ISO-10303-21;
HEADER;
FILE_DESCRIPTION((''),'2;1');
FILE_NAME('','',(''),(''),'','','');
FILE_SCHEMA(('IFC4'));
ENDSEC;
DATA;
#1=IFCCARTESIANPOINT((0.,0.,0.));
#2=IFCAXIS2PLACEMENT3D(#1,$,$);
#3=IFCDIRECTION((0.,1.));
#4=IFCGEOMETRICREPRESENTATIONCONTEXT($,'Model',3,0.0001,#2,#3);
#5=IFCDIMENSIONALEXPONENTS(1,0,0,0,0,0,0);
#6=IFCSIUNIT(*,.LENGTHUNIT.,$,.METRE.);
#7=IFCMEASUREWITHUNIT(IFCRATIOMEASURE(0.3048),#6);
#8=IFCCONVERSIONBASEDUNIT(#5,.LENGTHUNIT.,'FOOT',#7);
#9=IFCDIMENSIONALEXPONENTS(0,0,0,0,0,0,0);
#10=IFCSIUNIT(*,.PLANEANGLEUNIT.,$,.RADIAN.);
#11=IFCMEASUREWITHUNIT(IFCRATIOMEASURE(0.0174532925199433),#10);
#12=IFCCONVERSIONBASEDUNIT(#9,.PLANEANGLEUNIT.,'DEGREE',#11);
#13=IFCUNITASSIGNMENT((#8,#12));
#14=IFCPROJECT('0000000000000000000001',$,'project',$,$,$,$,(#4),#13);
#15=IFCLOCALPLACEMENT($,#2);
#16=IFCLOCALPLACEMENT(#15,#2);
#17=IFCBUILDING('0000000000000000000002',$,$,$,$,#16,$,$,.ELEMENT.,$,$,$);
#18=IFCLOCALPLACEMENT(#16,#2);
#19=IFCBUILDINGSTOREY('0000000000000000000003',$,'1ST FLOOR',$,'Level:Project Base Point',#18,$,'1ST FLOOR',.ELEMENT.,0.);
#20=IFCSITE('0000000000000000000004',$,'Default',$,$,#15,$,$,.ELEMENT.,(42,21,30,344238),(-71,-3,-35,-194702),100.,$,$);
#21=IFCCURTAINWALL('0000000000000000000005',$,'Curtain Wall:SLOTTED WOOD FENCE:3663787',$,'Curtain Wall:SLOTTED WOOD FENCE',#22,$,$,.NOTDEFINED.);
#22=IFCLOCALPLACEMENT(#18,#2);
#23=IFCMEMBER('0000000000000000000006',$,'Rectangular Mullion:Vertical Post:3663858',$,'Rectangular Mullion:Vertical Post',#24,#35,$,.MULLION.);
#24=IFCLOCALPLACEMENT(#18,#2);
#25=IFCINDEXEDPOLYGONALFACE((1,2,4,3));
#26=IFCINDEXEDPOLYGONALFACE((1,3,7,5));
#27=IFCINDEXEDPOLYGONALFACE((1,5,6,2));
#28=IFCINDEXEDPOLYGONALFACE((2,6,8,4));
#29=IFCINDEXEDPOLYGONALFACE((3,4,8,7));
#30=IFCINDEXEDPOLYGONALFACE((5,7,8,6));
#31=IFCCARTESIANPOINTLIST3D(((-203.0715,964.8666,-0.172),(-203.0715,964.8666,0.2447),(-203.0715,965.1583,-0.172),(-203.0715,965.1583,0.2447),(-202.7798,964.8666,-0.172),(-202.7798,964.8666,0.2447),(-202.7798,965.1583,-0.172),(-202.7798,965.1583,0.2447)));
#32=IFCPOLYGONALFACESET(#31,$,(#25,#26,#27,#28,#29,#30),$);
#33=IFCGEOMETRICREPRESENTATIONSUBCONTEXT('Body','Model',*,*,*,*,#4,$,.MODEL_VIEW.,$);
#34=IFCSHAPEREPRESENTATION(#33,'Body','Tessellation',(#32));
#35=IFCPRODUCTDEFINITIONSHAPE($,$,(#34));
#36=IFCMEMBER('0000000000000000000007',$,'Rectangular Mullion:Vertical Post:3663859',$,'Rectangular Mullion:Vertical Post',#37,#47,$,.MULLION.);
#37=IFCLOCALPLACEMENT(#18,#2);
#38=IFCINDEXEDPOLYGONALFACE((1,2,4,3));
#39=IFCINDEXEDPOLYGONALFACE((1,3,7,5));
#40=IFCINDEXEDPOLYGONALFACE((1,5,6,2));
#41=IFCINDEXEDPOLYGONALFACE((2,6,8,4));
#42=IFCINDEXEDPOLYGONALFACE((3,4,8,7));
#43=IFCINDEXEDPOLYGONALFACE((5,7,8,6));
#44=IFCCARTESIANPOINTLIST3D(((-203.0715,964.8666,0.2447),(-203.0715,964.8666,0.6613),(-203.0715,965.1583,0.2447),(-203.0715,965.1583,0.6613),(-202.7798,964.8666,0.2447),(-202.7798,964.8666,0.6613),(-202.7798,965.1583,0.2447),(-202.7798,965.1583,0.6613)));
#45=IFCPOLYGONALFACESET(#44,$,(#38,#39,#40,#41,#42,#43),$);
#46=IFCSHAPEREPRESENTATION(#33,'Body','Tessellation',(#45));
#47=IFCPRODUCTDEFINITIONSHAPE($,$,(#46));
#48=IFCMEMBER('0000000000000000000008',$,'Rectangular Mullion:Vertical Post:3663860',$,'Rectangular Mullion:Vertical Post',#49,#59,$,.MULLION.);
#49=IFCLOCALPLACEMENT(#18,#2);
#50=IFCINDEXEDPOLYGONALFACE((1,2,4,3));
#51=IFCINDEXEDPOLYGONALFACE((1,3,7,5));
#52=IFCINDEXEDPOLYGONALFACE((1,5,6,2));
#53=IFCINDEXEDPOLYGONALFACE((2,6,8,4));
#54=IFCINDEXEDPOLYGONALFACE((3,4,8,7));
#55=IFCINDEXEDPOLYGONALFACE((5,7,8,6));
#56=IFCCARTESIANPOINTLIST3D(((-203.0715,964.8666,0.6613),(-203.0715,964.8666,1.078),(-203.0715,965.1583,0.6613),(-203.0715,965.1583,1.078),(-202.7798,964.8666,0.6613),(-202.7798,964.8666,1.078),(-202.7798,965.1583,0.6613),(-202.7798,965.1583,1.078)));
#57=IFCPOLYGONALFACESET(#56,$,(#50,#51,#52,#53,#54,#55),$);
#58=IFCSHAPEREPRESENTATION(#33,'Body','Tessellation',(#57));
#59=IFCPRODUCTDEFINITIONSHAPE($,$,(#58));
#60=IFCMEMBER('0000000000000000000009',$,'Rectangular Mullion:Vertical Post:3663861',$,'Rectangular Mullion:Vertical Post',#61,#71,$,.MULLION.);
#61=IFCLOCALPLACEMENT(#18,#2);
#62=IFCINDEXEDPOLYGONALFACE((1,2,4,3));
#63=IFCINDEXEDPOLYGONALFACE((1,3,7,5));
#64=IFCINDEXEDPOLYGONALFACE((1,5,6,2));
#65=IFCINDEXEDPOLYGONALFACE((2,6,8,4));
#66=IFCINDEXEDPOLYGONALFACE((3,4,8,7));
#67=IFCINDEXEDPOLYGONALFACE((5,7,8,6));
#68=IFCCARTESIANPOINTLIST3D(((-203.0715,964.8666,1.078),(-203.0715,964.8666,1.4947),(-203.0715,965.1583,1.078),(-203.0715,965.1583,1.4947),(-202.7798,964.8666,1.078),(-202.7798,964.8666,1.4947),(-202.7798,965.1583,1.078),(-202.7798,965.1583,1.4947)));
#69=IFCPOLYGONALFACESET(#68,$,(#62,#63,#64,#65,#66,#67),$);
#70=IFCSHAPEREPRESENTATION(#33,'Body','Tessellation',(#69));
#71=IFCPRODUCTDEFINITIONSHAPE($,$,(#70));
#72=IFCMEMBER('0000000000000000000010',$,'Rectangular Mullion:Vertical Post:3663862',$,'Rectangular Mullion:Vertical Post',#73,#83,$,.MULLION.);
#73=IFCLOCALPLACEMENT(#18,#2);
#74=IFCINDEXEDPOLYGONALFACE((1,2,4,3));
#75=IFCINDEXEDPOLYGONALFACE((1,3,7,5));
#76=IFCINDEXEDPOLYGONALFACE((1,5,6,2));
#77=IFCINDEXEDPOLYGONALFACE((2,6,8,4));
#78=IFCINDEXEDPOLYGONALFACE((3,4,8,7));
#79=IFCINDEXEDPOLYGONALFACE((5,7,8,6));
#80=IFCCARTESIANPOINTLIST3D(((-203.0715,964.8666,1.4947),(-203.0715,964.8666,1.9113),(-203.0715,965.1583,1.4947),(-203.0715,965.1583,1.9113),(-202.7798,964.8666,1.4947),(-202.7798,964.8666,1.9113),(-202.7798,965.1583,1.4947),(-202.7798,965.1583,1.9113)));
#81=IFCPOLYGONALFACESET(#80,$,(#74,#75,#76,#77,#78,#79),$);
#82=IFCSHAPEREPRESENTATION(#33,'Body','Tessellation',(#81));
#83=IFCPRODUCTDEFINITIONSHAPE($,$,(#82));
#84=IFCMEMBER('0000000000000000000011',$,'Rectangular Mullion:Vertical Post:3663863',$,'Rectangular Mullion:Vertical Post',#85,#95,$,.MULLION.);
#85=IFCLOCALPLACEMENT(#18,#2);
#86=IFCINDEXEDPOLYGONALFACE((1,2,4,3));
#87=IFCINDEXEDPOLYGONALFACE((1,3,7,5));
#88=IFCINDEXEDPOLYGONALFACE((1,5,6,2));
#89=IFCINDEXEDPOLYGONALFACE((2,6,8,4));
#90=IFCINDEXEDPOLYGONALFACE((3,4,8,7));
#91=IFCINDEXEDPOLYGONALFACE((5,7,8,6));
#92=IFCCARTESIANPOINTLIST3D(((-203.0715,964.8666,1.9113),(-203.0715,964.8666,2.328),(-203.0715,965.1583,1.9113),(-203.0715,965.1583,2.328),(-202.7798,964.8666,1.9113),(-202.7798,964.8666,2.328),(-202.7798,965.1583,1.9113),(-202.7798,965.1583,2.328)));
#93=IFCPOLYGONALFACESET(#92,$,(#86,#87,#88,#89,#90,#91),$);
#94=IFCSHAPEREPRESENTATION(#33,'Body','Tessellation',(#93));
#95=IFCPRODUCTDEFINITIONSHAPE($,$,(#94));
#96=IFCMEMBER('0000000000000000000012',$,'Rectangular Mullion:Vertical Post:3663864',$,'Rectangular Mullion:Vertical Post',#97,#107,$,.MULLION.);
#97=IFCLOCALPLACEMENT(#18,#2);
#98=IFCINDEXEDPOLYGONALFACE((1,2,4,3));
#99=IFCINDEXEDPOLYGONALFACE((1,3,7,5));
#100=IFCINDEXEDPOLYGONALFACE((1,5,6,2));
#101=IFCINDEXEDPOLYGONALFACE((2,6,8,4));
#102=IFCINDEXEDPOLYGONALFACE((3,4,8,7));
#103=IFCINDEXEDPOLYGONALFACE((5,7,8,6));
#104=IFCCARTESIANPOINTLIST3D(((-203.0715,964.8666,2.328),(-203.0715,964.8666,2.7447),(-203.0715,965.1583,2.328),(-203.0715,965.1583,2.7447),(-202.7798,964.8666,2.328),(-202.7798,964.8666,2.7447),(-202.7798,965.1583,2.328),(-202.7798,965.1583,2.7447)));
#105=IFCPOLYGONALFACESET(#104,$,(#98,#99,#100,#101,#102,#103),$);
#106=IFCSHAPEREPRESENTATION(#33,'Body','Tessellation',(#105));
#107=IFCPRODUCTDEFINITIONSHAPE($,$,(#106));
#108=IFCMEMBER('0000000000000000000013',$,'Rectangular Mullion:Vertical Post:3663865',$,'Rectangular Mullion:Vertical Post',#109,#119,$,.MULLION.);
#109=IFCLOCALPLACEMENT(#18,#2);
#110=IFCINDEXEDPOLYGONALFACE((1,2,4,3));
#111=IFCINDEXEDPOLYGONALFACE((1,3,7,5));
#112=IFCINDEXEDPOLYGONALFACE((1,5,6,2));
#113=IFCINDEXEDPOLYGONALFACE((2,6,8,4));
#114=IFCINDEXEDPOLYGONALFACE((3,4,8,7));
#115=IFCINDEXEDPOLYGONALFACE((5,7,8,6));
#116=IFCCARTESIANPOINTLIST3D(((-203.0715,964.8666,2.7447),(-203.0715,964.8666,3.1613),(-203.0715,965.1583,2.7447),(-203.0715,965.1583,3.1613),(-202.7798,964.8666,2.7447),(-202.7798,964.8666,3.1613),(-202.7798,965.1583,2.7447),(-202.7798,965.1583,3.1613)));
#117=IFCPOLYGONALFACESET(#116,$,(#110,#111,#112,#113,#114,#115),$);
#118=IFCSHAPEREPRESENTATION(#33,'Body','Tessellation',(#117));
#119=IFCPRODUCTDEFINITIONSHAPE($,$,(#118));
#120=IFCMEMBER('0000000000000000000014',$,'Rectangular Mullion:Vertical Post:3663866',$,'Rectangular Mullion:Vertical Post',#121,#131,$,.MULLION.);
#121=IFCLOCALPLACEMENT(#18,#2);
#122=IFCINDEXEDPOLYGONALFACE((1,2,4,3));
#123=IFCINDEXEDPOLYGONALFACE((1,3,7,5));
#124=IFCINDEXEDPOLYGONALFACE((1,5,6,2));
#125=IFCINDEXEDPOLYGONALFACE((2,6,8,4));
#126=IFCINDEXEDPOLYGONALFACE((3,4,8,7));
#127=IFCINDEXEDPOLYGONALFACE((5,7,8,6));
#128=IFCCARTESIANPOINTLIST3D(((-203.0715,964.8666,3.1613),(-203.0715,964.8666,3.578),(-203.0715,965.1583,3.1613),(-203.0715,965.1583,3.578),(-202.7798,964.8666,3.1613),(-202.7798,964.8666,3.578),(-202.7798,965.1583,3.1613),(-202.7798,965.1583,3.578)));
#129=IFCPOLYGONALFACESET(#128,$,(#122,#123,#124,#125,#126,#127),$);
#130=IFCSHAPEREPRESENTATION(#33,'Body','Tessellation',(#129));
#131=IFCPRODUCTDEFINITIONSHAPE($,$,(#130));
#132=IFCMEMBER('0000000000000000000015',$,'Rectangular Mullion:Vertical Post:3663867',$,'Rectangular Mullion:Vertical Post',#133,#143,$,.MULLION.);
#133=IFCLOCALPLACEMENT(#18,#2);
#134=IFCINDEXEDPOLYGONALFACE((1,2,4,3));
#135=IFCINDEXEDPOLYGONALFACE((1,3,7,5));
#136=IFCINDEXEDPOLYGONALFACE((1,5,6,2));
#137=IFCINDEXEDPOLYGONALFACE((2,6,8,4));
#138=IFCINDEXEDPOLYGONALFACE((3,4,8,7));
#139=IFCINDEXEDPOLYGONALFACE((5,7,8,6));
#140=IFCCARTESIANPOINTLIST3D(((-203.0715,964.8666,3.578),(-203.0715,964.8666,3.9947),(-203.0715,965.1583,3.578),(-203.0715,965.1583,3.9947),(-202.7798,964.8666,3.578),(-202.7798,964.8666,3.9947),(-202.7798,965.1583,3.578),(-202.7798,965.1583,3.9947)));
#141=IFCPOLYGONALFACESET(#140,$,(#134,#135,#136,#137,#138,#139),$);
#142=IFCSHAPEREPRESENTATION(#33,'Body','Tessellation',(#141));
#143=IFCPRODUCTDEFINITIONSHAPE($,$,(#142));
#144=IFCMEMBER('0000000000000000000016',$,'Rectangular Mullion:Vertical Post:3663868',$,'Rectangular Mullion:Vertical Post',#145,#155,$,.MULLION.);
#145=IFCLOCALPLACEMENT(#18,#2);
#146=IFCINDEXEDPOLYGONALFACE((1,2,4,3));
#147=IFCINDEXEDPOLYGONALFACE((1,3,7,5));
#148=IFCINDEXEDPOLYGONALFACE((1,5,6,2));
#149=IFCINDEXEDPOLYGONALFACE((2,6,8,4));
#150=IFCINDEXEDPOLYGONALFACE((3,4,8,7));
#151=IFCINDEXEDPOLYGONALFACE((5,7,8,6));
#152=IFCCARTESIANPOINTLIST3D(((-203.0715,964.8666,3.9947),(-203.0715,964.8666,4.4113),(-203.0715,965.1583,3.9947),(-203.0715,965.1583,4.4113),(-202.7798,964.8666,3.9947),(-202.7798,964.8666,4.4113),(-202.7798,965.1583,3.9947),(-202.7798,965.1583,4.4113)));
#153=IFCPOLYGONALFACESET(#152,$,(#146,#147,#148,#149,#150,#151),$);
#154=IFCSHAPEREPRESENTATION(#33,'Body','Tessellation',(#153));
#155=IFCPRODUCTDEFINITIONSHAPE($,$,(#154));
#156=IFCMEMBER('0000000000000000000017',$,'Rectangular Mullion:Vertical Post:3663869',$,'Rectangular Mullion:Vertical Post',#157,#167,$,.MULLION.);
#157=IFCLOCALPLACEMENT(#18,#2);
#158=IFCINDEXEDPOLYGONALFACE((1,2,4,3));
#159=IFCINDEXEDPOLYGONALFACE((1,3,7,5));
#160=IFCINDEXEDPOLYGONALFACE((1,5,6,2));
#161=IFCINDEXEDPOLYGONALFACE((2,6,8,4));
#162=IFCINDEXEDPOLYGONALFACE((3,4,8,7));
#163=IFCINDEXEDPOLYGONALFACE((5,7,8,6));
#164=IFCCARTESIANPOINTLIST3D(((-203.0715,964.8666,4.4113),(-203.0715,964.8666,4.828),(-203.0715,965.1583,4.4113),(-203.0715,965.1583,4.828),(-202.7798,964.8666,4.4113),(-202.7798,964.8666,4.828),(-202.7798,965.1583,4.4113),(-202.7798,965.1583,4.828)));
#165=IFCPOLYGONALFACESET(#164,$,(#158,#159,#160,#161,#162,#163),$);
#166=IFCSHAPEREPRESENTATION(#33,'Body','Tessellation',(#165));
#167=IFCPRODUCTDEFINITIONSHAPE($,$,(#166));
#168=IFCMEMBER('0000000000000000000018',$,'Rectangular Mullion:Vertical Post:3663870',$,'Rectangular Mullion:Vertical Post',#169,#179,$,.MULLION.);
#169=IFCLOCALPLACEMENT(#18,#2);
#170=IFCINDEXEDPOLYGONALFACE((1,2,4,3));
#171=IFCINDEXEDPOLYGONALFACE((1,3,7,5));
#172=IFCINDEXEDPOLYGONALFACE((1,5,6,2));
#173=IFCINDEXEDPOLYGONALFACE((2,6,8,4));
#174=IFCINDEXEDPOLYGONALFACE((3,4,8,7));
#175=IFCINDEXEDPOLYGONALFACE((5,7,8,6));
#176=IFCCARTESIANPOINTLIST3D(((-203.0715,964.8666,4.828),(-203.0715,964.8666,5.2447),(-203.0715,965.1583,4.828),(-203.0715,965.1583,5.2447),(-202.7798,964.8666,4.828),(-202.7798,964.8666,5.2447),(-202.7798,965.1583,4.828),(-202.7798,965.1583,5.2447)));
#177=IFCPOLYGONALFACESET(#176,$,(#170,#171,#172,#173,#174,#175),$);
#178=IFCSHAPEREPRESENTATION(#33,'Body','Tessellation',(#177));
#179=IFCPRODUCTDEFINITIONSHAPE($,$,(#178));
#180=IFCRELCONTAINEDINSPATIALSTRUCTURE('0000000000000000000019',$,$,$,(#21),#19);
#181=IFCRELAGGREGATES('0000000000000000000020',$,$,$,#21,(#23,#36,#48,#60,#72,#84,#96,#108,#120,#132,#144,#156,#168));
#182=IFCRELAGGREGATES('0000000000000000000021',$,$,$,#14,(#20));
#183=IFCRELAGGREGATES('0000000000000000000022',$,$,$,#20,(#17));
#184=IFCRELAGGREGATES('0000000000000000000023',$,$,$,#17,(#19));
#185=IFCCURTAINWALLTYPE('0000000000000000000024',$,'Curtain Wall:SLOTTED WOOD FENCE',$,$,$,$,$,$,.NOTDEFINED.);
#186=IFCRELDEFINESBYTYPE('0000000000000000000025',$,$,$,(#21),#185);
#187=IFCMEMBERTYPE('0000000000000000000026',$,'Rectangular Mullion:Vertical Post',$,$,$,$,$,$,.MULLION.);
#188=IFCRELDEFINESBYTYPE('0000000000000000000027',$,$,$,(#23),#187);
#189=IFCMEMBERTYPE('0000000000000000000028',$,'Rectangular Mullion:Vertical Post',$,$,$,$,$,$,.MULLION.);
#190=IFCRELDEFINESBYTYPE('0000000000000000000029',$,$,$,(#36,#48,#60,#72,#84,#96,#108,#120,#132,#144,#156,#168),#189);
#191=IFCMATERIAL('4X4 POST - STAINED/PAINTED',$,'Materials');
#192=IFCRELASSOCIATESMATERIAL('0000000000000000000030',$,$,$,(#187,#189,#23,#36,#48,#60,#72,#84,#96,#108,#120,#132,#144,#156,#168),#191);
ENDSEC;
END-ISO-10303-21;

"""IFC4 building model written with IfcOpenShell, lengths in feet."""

from ifc_helpers import new_model, entity, si_unit, converted_unit, direction, frame, origin, origin_2d_with_axis, place, context, subcontext, project, spatial, rectangle, extrude, source, transform, mapped, material, material_profile, profile_set, profile_usage, type_object, type_shapes, element, aggregate, save


model = new_model("IFC4")

# Units and contexts
model_context = context("Model", 3, precision=0.0001, world=origin(), true_north=direction((0.0, 1.0)))
body_context = subcontext(model_context, "Body", "Model", "MODEL_VIEW")
ifc_project = project(units=[converted_unit("LENGTHUNIT", "FOOT", entity("IfcRatioMeasure", 0.3048), si_unit("LENGTHUNIT", "METRE"), dimensions=[1, 0, 0, 0, 0, 0, 0]), converted_unit("PLANEANGLEUNIT", "DEGREE", entity("IfcRatioMeasure", 0.0174532925199433), si_unit("PLANEANGLEUNIT", "RADIAN"), dimensions=[0, 0, 0, 0, 0, 0, 0])], contexts=[model_context])

# Site, building, storey
site_placement = place(None, origin())
site = spatial("IfcSite", under=ifc_project, at=site_placement, Name="Default", CompositionType="ELEMENT", RefLatitude=(42, 21, 30, 344238), RefLongitude=(-71, -3, -35, -194702), RefElevation=100.0)
building_placement = place(site_placement, origin())
building = spatial("IfcBuilding", under=site, at=building_placement, CompositionType="ELEMENT")
storey_placement = place(building_placement, origin())
storey = spatial("IfcBuildingStorey", under=building, at=storey_placement, Name="1ST FLOOR", ObjectType="Level:Project Base Point", LongName="1ST FLOOR", CompositionType="ELEMENT", Elevation=0.0)

# Curtain wall, members
curtain_wall_type = type_object("IfcCurtainWallType", Name="Curtain Wall:SLOTTED WOOD FENCE", PredefinedType="NOTDEFINED")
curtain_wall_placement = place(storey_placement, origin())
curtain_wall = element("IfcCurtainWall", 1, at=curtain_wall_placement, inside=storey, type_object=curtain_wall_type, Name="Curtain Wall:SLOTTED WOOD FENCE:3663787", ObjectType="Curtain Wall:SLOTTED WOOD FENCE", PredefinedType="NOTDEFINED")
ifc_material_1 = material(Name="4X4 POST - STAINED/PAINTED", Category="Materials")
ifc_material_profile = material_profile(ifc_material_1, rectangle(XDim=0.2917, YDim=0.2917, at=origin_2d_with_axis()), Name="Vertical Post")
ifc_profile_set = profile_set([ifc_material_profile], Name="Vertical Post")
ifc_profile_usage_1 = profile_usage(ifc_profile_set)
member_type_1 = type_object("IfcMemberType", Name="Rectangular Mullion:Vertical Post", PredefinedType="MULLION", material=ifc_profile_set)
shared_shape_1 = source(origin(), body_context, "Body", "SweptSolid", [
    extrude(rectangle(XDim=0.2917, YDim=0.2917, at=origin_2d_with_axis()), frame((-0.1458, -0.2083, -0.4167), z_axis=(0.0, 0.0, 1.0), x_axis=(0.0, -1.0, 0.0)), (0.0, 0.0, 1.0), 0.4167),
])
type_shapes(member_type_1, [shared_shape_1])
member_1_placement = place(storey_placement, frame((-203.134, 964.8666, -0.172), z_axis=(0.0, 0.0, -1.0), x_axis=(0.0, -1.0, 0.0)))
member_1 = element("IfcMember", 2, at=member_1_placement, type_object=member_type_1, material=ifc_profile_usage_1, Name="Rectangular Mullion:Vertical Post:3663858", ObjectType="Rectangular Mullion:Vertical Post", PredefinedType="MULLION", context=body_context, shape_type="MappedRepresentation", body=[
    mapped(shared_shape_1, transform((0.0, 0.0, 0.0), scale=1.0)),
])
ifc_profile_usage_2 = profile_usage(ifc_profile_set)
member_type_2 = type_object("IfcMemberType", Name="Rectangular Mullion:Vertical Post", PredefinedType="MULLION", material=ifc_profile_set)
shared_shape_2 = source(origin(), body_context, "Body", "SweptSolid", [
    extrude(rectangle(XDim=0.2917, YDim=0.2917, at=origin_2d_with_axis()), frame((-0.1458, -0.2083, -0.4167), z_axis=(0.0, 0.0, 1.0), x_axis=(0.0, -1.0, 0.0)), (0.0, 0.0, 1.0), 0.4167),
])
type_shapes(member_type_2, [shared_shape_2])
member_2_placement = place(storey_placement, frame((-203.134, 964.8666, 0.2447), z_axis=(0.0, 0.0, -1.0), x_axis=(0.0, -1.0, 0.0)))
member_2 = element("IfcMember", 3, at=member_2_placement, type_object=member_type_2, material=ifc_profile_usage_2, Name="Rectangular Mullion:Vertical Post:3663859", ObjectType="Rectangular Mullion:Vertical Post", PredefinedType="MULLION", context=body_context, shape_type="MappedRepresentation", body=[
    mapped(shared_shape_2, transform((0.0, 0.0, 0.0), scale=1.0)),
])
ifc_profile_usage_3 = profile_usage(ifc_profile_set)
member_3_placement = place(storey_placement, frame((-203.134, 964.8666, 0.6613), z_axis=(0.0, 0.0, -1.0), x_axis=(0.0, -1.0, 0.0)))
member_3 = element("IfcMember", 4, at=member_3_placement, type_object=member_type_2, material=ifc_profile_usage_3, Name="Rectangular Mullion:Vertical Post:3663860", ObjectType="Rectangular Mullion:Vertical Post", PredefinedType="MULLION", context=body_context, shape_type="MappedRepresentation", body=[
    mapped(shared_shape_2, transform((0.0, 0.0, 0.0), scale=1.0)),
])
ifc_profile_usage_4 = profile_usage(ifc_profile_set)
member_4_placement = place(storey_placement, frame((-203.134, 964.8666, 1.078), z_axis=(0.0, 0.0, -1.0), x_axis=(0.0, -1.0, 0.0)))
member_4 = element("IfcMember", 5, at=member_4_placement, type_object=member_type_2, material=ifc_profile_usage_4, Name="Rectangular Mullion:Vertical Post:3663861", ObjectType="Rectangular Mullion:Vertical Post", PredefinedType="MULLION", context=body_context, shape_type="MappedRepresentation", body=[
    mapped(shared_shape_2, transform((0.0, 0.0, 0.0), scale=1.0)),
])
ifc_profile_usage_5 = profile_usage(ifc_profile_set)
member_5_placement = place(storey_placement, frame((-203.134, 964.8666, 1.4947), z_axis=(0.0, 0.0, -1.0), x_axis=(0.0, -1.0, 0.0)))
member_5 = element("IfcMember", 6, at=member_5_placement, type_object=member_type_2, material=ifc_profile_usage_5, Name="Rectangular Mullion:Vertical Post:3663862", ObjectType="Rectangular Mullion:Vertical Post", PredefinedType="MULLION", context=body_context, shape_type="MappedRepresentation", body=[
    mapped(shared_shape_2, transform((0.0, 0.0, 0.0), scale=1.0)),
])
ifc_profile_usage_6 = profile_usage(ifc_profile_set)
member_6_placement = place(storey_placement, frame((-203.134, 964.8666, 1.9113), z_axis=(0.0, 0.0, -1.0), x_axis=(0.0, -1.0, 0.0)))
member_6 = element("IfcMember", 7, at=member_6_placement, type_object=member_type_2, material=ifc_profile_usage_6, Name="Rectangular Mullion:Vertical Post:3663863", ObjectType="Rectangular Mullion:Vertical Post", PredefinedType="MULLION", context=body_context, shape_type="MappedRepresentation", body=[
    mapped(shared_shape_2, transform((0.0, 0.0, 0.0), scale=1.0)),
])
ifc_profile_usage_7 = profile_usage(ifc_profile_set)
member_7_placement = place(storey_placement, frame((-203.134, 964.8666, 2.328), z_axis=(0.0, 0.0, -1.0), x_axis=(0.0, -1.0, 0.0)))
member_7 = element("IfcMember", 8, at=member_7_placement, type_object=member_type_2, material=ifc_profile_usage_7, Name="Rectangular Mullion:Vertical Post:3663864", ObjectType="Rectangular Mullion:Vertical Post", PredefinedType="MULLION", context=body_context, shape_type="MappedRepresentation", body=[
    mapped(shared_shape_2, transform((0.0, 0.0, 0.0), scale=1.0)),
])
ifc_profile_usage_8 = profile_usage(ifc_profile_set)
member_8_placement = place(storey_placement, frame((-203.134, 964.8666, 2.7447), z_axis=(0.0, 0.0, -1.0), x_axis=(0.0, -1.0, 0.0)))
member_8 = element("IfcMember", 9, at=member_8_placement, type_object=member_type_2, material=ifc_profile_usage_8, Name="Rectangular Mullion:Vertical Post:3663865", ObjectType="Rectangular Mullion:Vertical Post", PredefinedType="MULLION", context=body_context, shape_type="MappedRepresentation", body=[
    mapped(shared_shape_2, transform((0.0, 0.0, 0.0), scale=1.0)),
])
ifc_profile_usage_9 = profile_usage(ifc_profile_set)
member_9_placement = place(storey_placement, frame((-203.134, 964.8666, 3.1613), z_axis=(0.0, 0.0, -1.0), x_axis=(0.0, -1.0, 0.0)))
member_9 = element("IfcMember", 10, at=member_9_placement, type_object=member_type_2, material=ifc_profile_usage_9, Name="Rectangular Mullion:Vertical Post:3663866", ObjectType="Rectangular Mullion:Vertical Post", PredefinedType="MULLION", context=body_context, shape_type="MappedRepresentation", body=[
    mapped(shared_shape_2, transform((0.0, 0.0, 0.0), scale=1.0)),
])
ifc_profile_usage_10 = profile_usage(ifc_profile_set)
member_10_placement = place(storey_placement, frame((-203.134, 964.8666, 3.578), z_axis=(0.0, 0.0, -1.0), x_axis=(0.0, -1.0, 0.0)))
member_10 = element("IfcMember", 11, at=member_10_placement, type_object=member_type_2, material=ifc_profile_usage_10, Name="Rectangular Mullion:Vertical Post:3663867", ObjectType="Rectangular Mullion:Vertical Post", PredefinedType="MULLION", context=body_context, shape_type="MappedRepresentation", body=[
    mapped(shared_shape_2, transform((0.0, 0.0, 0.0), scale=1.0)),
])
ifc_profile_usage_11 = profile_usage(ifc_profile_set)
member_11_placement = place(storey_placement, frame((-203.134, 964.8666, 3.9947), z_axis=(0.0, 0.0, -1.0), x_axis=(0.0, -1.0, 0.0)))
member_11 = element("IfcMember", 12, at=member_11_placement, type_object=member_type_2, material=ifc_profile_usage_11, Name="Rectangular Mullion:Vertical Post:3663868", ObjectType="Rectangular Mullion:Vertical Post", PredefinedType="MULLION", context=body_context, shape_type="MappedRepresentation", body=[
    mapped(shared_shape_2, transform((0.0, 0.0, 0.0), scale=1.0)),
])
ifc_profile_usage_12 = profile_usage(ifc_profile_set)
member_12_placement = place(storey_placement, frame((-203.134, 964.8666, 4.4113), z_axis=(0.0, 0.0, -1.0), x_axis=(0.0, -1.0, 0.0)))
member_12 = element("IfcMember", 13, at=member_12_placement, type_object=member_type_2, material=ifc_profile_usage_12, Name="Rectangular Mullion:Vertical Post:3663869", ObjectType="Rectangular Mullion:Vertical Post", PredefinedType="MULLION", context=body_context, shape_type="MappedRepresentation", body=[
    mapped(shared_shape_2, transform((0.0, 0.0, 0.0), scale=1.0)),
])
ifc_profile_usage_13 = profile_usage(ifc_profile_set)
member_13_placement = place(storey_placement, frame((-203.134, 964.8666, 4.828), z_axis=(0.0, 0.0, -1.0), x_axis=(0.0, -1.0, 0.0)))
member_13 = element("IfcMember", 14, at=member_13_placement, type_object=member_type_2, material=ifc_profile_usage_13, Name="Rectangular Mullion:Vertical Post:3663870", ObjectType="Rectangular Mullion:Vertical Post", PredefinedType="MULLION", context=body_context, shape_type="MappedRepresentation", body=[
    mapped(shared_shape_2, transform((0.0, 0.0, 0.0), scale=1.0)),
])
aggregate(curtain_wall, [member_1, member_2, member_3, member_4, member_5, member_6, member_7, member_8, member_9, member_10, member_11, member_12, member_13])

save(model, "model.ifc")
